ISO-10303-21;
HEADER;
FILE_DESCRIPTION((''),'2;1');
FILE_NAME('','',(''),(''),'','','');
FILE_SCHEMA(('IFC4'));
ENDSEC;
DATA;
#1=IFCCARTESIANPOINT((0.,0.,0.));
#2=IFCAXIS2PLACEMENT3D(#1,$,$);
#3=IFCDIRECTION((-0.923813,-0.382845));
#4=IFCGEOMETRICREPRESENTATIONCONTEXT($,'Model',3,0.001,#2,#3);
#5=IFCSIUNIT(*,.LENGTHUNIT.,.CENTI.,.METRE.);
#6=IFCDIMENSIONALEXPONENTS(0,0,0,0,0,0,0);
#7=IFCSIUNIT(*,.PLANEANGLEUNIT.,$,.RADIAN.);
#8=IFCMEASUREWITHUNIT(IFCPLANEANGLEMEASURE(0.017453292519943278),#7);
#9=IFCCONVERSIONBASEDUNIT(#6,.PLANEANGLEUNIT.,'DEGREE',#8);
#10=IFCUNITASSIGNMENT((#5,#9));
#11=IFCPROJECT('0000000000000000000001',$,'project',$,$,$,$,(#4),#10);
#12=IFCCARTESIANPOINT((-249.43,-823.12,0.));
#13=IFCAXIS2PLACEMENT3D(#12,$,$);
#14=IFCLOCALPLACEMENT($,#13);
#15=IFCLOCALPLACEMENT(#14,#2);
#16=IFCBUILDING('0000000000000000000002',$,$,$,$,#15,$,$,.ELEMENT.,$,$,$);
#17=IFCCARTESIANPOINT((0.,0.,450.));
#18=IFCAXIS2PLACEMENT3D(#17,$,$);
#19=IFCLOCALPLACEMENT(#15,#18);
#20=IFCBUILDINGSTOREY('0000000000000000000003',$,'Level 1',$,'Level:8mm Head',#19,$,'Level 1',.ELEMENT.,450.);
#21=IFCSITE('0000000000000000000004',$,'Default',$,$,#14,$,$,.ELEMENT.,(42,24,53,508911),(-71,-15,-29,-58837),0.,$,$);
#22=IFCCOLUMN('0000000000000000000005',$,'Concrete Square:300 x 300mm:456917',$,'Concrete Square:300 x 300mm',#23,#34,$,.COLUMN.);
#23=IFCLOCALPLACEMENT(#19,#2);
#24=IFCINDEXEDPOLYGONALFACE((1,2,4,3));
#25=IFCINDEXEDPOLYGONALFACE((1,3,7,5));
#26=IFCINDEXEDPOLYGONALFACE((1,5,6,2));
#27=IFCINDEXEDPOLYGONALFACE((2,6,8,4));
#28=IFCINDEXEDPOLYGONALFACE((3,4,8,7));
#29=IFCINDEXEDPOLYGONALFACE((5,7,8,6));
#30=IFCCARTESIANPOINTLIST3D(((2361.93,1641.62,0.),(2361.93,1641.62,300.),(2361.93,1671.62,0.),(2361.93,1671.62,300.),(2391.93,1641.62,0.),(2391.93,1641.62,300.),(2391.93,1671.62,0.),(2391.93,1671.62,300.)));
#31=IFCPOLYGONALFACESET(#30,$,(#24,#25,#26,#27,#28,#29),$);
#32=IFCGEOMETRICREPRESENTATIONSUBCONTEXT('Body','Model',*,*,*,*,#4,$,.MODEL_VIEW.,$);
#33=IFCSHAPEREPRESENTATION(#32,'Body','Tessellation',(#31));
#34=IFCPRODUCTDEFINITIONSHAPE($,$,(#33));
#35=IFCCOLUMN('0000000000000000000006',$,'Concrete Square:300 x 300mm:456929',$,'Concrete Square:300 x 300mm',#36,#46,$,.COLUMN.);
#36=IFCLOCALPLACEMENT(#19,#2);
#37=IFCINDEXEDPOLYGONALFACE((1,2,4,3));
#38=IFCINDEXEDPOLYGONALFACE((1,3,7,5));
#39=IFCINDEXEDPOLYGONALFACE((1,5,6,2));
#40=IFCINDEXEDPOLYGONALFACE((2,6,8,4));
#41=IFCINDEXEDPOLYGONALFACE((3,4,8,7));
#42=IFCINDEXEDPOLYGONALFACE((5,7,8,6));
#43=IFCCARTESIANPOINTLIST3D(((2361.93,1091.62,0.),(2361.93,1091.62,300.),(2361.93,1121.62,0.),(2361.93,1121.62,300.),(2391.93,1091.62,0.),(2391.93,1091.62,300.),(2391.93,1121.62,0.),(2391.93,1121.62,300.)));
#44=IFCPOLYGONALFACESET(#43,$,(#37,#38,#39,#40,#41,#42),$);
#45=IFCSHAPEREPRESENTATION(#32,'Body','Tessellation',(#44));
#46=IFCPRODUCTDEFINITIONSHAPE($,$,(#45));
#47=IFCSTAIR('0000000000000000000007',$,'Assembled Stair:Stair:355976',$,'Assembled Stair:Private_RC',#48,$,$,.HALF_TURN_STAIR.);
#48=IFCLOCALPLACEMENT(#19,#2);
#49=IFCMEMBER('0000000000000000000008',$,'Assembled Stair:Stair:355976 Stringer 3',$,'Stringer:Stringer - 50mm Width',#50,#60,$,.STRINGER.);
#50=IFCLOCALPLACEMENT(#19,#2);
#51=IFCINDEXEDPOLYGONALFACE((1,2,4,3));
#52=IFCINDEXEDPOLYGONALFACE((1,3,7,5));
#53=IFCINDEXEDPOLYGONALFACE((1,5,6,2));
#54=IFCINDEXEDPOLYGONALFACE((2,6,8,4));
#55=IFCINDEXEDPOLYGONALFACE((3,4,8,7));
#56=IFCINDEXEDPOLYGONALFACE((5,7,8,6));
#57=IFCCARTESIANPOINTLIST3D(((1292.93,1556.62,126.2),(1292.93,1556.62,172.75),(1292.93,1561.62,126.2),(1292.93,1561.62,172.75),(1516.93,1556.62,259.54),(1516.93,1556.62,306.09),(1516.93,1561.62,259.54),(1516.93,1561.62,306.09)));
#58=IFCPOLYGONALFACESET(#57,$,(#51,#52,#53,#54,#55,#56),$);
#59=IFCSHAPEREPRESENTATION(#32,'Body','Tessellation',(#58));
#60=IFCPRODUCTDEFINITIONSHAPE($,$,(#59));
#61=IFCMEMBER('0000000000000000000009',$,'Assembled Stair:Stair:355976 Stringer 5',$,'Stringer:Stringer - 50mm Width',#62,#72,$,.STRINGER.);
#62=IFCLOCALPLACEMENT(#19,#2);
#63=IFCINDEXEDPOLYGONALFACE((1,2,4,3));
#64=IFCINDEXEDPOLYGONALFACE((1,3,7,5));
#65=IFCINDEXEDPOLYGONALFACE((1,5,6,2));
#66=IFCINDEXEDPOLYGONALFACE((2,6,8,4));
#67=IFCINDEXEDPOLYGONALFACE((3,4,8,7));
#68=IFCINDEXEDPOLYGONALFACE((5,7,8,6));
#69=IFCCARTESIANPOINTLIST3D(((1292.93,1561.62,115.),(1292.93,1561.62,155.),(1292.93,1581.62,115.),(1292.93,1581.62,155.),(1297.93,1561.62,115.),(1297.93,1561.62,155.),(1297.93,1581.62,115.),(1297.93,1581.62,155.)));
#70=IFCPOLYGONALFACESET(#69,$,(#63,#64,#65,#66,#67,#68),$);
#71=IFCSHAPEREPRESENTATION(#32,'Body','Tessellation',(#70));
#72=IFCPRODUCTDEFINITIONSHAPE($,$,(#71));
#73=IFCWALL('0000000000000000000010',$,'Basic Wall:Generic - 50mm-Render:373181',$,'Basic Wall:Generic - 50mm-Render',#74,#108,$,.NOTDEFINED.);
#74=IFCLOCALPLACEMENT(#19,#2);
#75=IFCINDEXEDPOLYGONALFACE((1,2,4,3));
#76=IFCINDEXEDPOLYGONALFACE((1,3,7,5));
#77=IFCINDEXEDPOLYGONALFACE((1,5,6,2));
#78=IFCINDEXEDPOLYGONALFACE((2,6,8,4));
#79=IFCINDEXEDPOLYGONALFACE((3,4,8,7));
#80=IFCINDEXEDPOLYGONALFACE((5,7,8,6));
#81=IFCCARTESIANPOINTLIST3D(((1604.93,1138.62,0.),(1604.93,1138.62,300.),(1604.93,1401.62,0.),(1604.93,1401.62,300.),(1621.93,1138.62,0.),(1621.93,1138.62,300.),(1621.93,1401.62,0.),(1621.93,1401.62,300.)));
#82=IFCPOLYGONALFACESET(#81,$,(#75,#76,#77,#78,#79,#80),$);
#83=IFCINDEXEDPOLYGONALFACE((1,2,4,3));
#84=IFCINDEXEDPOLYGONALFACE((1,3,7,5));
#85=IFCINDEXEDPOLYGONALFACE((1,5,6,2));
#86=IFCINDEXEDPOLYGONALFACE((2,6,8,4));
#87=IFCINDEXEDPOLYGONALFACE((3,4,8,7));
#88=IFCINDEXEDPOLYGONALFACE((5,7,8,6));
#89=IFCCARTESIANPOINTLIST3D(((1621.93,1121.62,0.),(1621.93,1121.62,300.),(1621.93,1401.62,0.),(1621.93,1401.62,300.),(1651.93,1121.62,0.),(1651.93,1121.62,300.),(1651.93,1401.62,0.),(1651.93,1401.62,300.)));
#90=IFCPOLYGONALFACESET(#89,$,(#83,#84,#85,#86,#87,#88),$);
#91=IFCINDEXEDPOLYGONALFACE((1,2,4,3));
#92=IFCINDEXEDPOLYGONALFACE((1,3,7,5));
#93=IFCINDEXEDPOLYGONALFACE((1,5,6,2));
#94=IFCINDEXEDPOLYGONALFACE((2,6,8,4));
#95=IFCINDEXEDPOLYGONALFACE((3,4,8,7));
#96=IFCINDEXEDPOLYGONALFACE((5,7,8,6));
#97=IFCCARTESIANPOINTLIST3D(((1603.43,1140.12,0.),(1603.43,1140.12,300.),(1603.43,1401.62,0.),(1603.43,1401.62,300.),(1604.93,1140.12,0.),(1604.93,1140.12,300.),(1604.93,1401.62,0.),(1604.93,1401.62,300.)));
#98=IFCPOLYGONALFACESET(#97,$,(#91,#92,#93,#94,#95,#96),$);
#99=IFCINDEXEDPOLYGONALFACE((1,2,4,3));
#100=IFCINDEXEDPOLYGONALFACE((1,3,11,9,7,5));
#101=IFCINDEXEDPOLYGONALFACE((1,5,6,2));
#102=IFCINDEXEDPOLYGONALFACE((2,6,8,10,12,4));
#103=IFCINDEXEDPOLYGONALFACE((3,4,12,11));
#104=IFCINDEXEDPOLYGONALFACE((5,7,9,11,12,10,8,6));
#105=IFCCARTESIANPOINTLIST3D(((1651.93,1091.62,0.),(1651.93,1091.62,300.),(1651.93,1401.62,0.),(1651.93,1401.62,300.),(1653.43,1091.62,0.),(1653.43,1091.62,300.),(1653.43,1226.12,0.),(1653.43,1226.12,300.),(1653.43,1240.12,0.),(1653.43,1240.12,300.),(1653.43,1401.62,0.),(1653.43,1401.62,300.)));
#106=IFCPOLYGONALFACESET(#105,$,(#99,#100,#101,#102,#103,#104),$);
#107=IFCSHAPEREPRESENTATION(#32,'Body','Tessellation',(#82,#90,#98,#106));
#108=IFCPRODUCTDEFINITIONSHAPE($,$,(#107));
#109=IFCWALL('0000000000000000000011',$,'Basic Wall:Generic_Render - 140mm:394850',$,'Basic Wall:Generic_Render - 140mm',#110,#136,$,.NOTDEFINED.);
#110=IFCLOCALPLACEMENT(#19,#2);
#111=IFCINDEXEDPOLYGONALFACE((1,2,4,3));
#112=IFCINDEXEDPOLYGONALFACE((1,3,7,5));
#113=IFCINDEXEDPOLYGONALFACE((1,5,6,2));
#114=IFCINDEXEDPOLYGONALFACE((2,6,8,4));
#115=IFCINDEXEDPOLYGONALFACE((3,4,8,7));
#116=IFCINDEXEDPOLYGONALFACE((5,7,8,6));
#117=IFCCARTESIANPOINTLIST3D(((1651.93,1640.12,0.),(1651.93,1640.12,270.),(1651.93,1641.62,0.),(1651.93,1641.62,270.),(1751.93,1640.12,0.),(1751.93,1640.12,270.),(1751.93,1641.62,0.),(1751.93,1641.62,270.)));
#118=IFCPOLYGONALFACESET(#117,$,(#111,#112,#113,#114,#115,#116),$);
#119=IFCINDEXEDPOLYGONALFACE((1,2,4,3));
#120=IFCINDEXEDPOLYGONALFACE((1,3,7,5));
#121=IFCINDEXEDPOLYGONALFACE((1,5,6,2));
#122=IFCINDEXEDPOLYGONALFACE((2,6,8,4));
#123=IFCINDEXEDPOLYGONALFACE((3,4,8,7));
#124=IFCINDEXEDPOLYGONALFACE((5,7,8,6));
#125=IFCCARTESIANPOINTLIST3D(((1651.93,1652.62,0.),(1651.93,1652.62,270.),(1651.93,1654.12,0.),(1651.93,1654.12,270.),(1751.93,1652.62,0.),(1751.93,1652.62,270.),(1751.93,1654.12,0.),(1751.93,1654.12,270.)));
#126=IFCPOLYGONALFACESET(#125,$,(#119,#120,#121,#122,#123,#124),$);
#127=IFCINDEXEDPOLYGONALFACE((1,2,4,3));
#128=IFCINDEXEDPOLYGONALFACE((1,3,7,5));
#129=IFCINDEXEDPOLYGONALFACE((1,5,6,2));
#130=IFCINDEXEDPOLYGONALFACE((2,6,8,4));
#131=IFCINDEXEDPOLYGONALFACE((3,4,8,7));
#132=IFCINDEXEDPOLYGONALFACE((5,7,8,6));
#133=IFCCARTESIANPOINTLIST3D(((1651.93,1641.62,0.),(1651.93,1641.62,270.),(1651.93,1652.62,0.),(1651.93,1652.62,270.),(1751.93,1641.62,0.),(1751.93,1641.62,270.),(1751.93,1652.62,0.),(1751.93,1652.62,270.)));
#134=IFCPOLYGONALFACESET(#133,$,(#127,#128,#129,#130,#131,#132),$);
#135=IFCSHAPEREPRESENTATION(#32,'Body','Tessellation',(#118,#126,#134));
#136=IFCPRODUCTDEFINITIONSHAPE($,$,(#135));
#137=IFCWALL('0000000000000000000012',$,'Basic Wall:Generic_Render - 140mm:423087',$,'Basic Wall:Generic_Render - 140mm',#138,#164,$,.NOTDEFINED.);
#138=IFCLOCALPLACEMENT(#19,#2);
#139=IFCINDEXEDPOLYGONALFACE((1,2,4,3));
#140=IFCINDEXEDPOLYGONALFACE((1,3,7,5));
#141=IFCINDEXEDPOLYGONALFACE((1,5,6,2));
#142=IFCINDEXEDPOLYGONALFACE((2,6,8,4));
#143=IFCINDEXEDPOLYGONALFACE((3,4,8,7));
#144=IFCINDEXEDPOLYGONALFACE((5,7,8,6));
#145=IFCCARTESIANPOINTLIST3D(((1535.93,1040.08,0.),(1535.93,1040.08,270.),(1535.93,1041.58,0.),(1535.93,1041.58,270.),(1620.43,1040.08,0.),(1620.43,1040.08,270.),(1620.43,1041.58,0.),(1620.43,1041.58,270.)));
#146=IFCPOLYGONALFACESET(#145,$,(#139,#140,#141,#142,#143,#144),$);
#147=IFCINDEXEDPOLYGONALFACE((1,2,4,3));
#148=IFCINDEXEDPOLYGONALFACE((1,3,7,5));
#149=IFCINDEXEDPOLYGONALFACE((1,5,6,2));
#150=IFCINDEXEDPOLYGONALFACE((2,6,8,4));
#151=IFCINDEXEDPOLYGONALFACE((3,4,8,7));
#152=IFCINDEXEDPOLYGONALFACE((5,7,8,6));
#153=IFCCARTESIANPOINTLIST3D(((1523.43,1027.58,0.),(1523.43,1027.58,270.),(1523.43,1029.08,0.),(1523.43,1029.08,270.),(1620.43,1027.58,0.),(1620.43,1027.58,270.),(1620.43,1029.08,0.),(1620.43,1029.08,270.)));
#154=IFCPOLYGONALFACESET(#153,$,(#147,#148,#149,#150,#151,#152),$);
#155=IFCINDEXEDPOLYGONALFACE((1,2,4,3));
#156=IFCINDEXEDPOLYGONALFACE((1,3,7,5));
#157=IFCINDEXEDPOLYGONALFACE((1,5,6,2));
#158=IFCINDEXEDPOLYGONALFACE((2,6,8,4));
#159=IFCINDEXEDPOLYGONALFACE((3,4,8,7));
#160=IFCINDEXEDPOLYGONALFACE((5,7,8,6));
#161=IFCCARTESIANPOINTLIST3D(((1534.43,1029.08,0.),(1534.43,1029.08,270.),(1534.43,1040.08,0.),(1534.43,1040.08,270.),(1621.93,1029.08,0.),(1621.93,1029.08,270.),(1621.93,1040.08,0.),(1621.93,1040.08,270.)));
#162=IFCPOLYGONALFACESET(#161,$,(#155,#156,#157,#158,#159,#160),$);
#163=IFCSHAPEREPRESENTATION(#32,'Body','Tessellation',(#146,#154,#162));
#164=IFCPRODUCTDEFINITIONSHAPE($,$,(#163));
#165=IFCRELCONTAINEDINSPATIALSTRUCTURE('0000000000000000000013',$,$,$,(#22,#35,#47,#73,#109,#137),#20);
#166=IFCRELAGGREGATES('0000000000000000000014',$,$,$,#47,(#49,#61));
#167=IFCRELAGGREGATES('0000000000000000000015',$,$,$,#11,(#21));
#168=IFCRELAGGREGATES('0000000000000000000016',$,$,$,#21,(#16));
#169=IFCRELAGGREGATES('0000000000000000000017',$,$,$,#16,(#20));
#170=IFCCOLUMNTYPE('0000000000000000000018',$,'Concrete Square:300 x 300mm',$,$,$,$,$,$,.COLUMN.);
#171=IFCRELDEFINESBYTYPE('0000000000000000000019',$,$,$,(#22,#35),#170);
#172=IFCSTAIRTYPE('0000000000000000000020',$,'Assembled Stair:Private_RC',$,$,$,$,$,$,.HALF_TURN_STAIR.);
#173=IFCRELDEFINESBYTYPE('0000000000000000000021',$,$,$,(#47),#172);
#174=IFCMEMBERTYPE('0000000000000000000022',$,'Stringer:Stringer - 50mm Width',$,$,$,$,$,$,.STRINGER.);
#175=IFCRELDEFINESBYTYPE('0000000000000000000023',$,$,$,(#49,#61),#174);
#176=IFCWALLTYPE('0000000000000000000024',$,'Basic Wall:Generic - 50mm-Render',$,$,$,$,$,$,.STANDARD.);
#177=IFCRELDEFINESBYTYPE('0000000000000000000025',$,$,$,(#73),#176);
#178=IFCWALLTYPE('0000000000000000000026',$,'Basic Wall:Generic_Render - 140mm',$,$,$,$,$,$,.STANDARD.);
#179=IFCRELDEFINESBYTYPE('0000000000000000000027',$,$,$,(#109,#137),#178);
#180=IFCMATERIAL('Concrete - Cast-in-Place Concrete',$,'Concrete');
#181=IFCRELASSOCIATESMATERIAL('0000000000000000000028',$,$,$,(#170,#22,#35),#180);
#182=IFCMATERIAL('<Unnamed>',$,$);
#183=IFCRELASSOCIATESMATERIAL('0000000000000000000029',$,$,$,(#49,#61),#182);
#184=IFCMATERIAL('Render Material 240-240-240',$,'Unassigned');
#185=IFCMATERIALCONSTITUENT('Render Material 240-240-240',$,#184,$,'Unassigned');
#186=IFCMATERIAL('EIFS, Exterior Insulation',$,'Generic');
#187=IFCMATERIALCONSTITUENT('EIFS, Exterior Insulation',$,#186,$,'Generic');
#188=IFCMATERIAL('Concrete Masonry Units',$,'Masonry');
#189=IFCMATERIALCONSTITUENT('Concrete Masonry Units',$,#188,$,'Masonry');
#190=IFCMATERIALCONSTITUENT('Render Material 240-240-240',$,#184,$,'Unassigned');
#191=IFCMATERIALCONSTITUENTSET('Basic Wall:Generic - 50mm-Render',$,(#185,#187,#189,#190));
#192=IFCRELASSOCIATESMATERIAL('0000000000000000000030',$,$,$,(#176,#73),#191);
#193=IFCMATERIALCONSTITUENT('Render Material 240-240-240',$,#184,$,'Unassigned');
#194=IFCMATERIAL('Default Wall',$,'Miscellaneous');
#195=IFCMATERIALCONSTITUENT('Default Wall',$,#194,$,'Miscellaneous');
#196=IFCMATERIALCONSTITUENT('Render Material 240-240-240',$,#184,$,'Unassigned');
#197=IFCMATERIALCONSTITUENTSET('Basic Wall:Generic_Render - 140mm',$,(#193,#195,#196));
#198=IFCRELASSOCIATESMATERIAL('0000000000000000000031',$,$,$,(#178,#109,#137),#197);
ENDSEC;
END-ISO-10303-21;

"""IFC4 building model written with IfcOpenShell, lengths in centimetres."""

from ifc_helpers import new_model, entity, si_unit, converted_unit, direction, frame, origin, place, context, subcontext, project, spatial, indexed_curve, outline, extrude, source, transform, mapped, material, constituent, constituent_set, type_object, type_shapes, element, aggregate, save


model = new_model("IFC4")

# Units and contexts
model_context = context("Model", 3, precision=0.001, world=origin(), true_north=direction((-0.923813, -0.382845)))
body_context = subcontext(model_context, "Body", "Model", "MODEL_VIEW")
ifc_project = project(units=[si_unit("LENGTHUNIT", "METRE", prefix="CENTI"), converted_unit("PLANEANGLEUNIT", "DEGREE", entity("IfcPlaneAngleMeasure", 0.017453292519943278), si_unit("PLANEANGLEUNIT", "RADIAN"), dimensions=[0, 0, 0, 0, 0, 0, 0])], contexts=[model_context])

# Site, building, storey
site_placement = place(None, frame((-249.43, -823.12, 0.0)))
site = spatial("IfcSite", under=ifc_project, at=site_placement, Name="Default", CompositionType="ELEMENT", RefLatitude=(42, 24, 53, 508911), RefLongitude=(-71, -15, -29, -58837), RefElevation=0.0)
building_placement = place(site_placement, origin())
building = spatial("IfcBuilding", under=site, at=building_placement, CompositionType="ELEMENT")
storey_placement = place(building_placement, frame((0.0, 0.0, 450.0)))
storey = spatial("IfcBuildingStorey", under=building, at=storey_placement, Name="Level 1", ObjectType="Level:8mm Head", LongName="Level 1", CompositionType="ELEMENT", Elevation=450.0)

# Columns
ifc_material_1 = material(Name="Concrete - Cast-in-Place Concrete", Category="Concrete")
column_type = type_object("IfcColumnType", Name="Concrete Square:300 x 300mm", PredefinedType="COLUMN", material=ifc_material_1)
shared_shape_1 = source(origin(), body_context, "Body", "SweptSolid", [
    extrude(outline(indexed_curve([(-15.0, -15.0), (15.0, -15.0), (15.0, 15.0), (-15.0, 15.0), (-15.0, -15.0)], self_intersect=False)), frame((0.0, 0.0, 450.0), z_axis=(0.0, 0.0, 1.0), x_axis=(-1.0, 0.0, 0.0)), (0.0, 0.0, 1.0), 300.0),
])
type_shapes(column_type, [shared_shape_1])
for number, where, name in (
    (1, (2376.93, 1656.62, -450.0), "Concrete Square:300 x 300mm:456917"),
    (2, (2376.93, 1106.62, -450.0), "Concrete Square:300 x 300mm:456929"),
):
    element("IfcColumn", number, at=place(storey_placement, frame(where)), inside=storey, type_object=column_type, material=ifc_material_1, Name=name, ObjectType="Concrete Square:300 x 300mm", PredefinedType="COLUMN", context=body_context, shape_type="MappedRepresentation", body=[
        mapped(shared_shape_1, transform((0.0, 0.0, 0.0), scale=1.0)),
    ])

# Stair, members
stair_type = type_object("IfcStairType", Name="Assembled Stair:Private_RC", PredefinedType="HALF_TURN_STAIR")
stair_placement = place(storey_placement, origin())
stair = element("IfcStair", 3, at=stair_placement, inside=storey, type_object=stair_type, Name="Assembled Stair:Stair:355976", ObjectType="Assembled Stair:Private_RC", PredefinedType="HALF_TURN_STAIR")
ifc_material_2 = material(Name="<Unnamed>")
member_type = type_object("IfcMemberType", Name="Stringer:Stringer - 50mm Width", PredefinedType="STRINGER")
member_1_placement = place(stair_placement, frame((1292.93, 1556.62, 126.2)))
member_1 = element("IfcMember", 4, at=member_1_placement, type_object=member_type, material=ifc_material_2, Name="Assembled Stair:Stair:355976 Stringer 3", ObjectType="Stringer:Stringer - 50mm Width", PredefinedType="STRINGER", context=body_context, shape_type="SweptSolid", body=[
    extrude(outline(indexed_curve([(-118.43, -20.0), (142.24, -20.0), (118.43, 20.0), (-142.24, 20.0), (-118.43, -20.0)], self_intersect=False)), frame((112.0, 0.0, 89.94), z_axis=(0.0, 1.0, 0.0), x_axis=(0.859293, 0.0, 0.511484)), (0.0, 0.0, 1.0), 5.0),
])
member_2_placement = place(stair_placement, frame((1292.93, 1561.62, 115.0)))
member_2 = element("IfcMember", 5, at=member_2_placement, type_object=member_type, material=ifc_material_2, Name="Assembled Stair:Stair:355976 Stringer 5", ObjectType="Stringer:Stringer - 50mm Width", PredefinedType="STRINGER", context=body_context, shape_type="SweptSolid", body=[
    extrude(outline(indexed_curve([(-10.0, -2.5), (10.0, -2.5), (10.0, 2.5), (-10.0, 2.5), (-10.0, -2.5)], self_intersect=False)), frame((2.5, 10.0, 0.0), z_axis=(0.0, 0.0, 1.0), x_axis=(0.0, 1.0, 0.0)), (0.0, 0.0, 1.0), 40.0),
])
aggregate(stair, [member_1, member_2])

# Walls
ifc_material_3 = material(Name="Render Material 240-240-240", Category="Unassigned")
ifc_material_4 = material(Name="Default Wall", Category="Miscellaneous")
ifc_constituent_1 = constituent(ifc_material_3, Name="Render Material 240-240-240", Category="Unassigned")
ifc_material_5 = material(Name="EIFS, Exterior Insulation", Category="Generic")
ifc_constituent_2 = constituent(ifc_material_5, Name="EIFS, Exterior Insulation", Category="Generic")
ifc_material_6 = material(Name="Concrete Masonry Units", Category="Masonry")
ifc_constituent_3 = constituent(ifc_material_6, Name="Concrete Masonry Units", Category="Masonry")
ifc_constituent_4 = constituent(ifc_material_3, Name="Render Material 240-240-240", Category="Unassigned")
ifc_constituent_set_1 = constituent_set(constituents=[ifc_constituent_1, ifc_constituent_2, ifc_constituent_3, ifc_constituent_4], Name="Basic Wall:Generic - 50mm-Render")
wall_type_1 = type_object("IfcWallType", Name="Basic Wall:Generic - 50mm-Render", PredefinedType="STANDARD", material=ifc_constituent_set_1)
wall_1_placement = place(storey_placement, frame((1628.43, 1401.62, 0.0), z_axis=(0.0, 0.0, 1.0), x_axis=(0.0, -1.0, 0.0)))
element("IfcWall", 6, at=wall_1_placement, inside=storey, type_object=wall_type_1, material=ifc_constituent_set_1, Name="Basic Wall:Generic - 50mm-Render:373181", ObjectType="Basic Wall:Generic - 50mm-Render", PredefinedType="NOTDEFINED", context=body_context, shape_type="SweptSolid", body=[
    extrude(outline(indexed_curve([(-8.5, -131.5), (8.5, -131.5), (8.5, 131.5), (-8.5, 131.5), (-8.5, -131.5)], self_intersect=False)), frame((131.5, -15.0, 0.0), z_axis=(0.0, 0.0, 1.0), x_axis=(0.0, 1.0, 0.0)), (0.0, 0.0, 1.0), 300.0),
    extrude(outline(indexed_curve([(-15.0, -140.0), (15.0, -140.0), (15.0, 140.0), (-15.0, 140.0), (-15.0, -140.0)], self_intersect=False)), frame((140.0, 8.5, 0.0), z_axis=(0.0, 0.0, 1.0), x_axis=(0.0, -1.0, 0.0)), (0.0, 0.0, 1.0), 300.0),
    extrude(outline(indexed_curve([(-0.75, -130.75), (0.75, -130.75), (0.75, 130.75), (-0.75, 130.75), (-0.75, -130.75)], self_intersect=False)), frame((130.75, -24.25, 0.0), z_axis=(0.0, 0.0, 1.0), x_axis=(0.0, 1.0, 0.0)), (0.0, 0.0, 1.0), 300.0),
    extrude(outline(indexed_curve([(-1.0, -150.5), (0.5, -150.5), (0.5, -16.0), (0.5, -2.0), (0.5, 159.5), (-1.0, 159.5), (-1.0, -150.5)], self_intersect=False)), frame((159.5, 24.5, 0.0), z_axis=(0.0, 0.0, 1.0), x_axis=(0.0, 1.0, 0.0)), (0.0, 0.0, 1.0), 300.0),
])
ifc_constituent_5 = constituent(ifc_material_3, Name="Render Material 240-240-240", Category="Unassigned")
ifc_constituent_6 = constituent(ifc_material_4, Name="Default Wall", Category="Miscellaneous")
ifc_constituent_7 = constituent(ifc_material_3, Name="Render Material 240-240-240", Category="Unassigned")
ifc_constituent_set_2 = constituent_set(constituents=[ifc_constituent_5, ifc_constituent_6, ifc_constituent_7], Name="Basic Wall:Generic_Render - 140mm")
wall_type_2 = type_object("IfcWallType", Name="Basic Wall:Generic_Render - 140mm", PredefinedType="STANDARD", material=ifc_constituent_set_2)
wall_2_placement = place(storey_placement, frame((1651.93, 1647.12, 0.0)))
element("IfcWall", 7, at=wall_2_placement, inside=storey, type_object=wall_type_2, material=ifc_constituent_set_2, Name="Basic Wall:Generic_Render - 140mm:394850", ObjectType="Basic Wall:Generic_Render - 140mm", PredefinedType="NOTDEFINED", context=body_context, shape_type="SweptSolid", body=[
    extrude(outline(indexed_curve([(-0.75, -50.0), (0.75, -50.0), (0.75, 50.0), (-0.75, 50.0), (-0.75, -50.0)], self_intersect=False)), frame((50.0, -6.25, 0.0), z_axis=(0.0, 0.0, 1.0), x_axis=(0.0, 1.0, 0.0)), (0.0, 0.0, 1.0), 270.0),
    extrude(outline(indexed_curve([(-0.75, -50.0), (0.75, -50.0), (0.75, 50.0), (-0.75, 50.0), (-0.75, -50.0)], self_intersect=False)), frame((50.0, 6.25, 0.0), z_axis=(0.0, 0.0, 1.0), x_axis=(0.0, -1.0, 0.0)), (0.0, 0.0, 1.0), 270.0),
    extrude(outline(indexed_curve([(-50.0, -5.5), (50.0, -5.5), (50.0, 5.5), (-50.0, 5.5), (-50.0, -5.5)], self_intersect=False)), frame((50.0, 0.0, 0.0)), (0.0, 0.0, 1.0), 270.0),
])
wall_3_placement = place(storey_placement, frame((1535.93, 1034.58, 0.0)))
element("IfcWall", 8, at=wall_3_placement, inside=storey, type_object=wall_type_2, material=ifc_constituent_set_2, Name="Basic Wall:Generic_Render - 140mm:423087", ObjectType="Basic Wall:Generic_Render - 140mm", PredefinedType="NOTDEFINED", context=body_context, shape_type="SweptSolid", body=[
    extrude(outline(indexed_curve([(-0.75, -42.25), (0.75, -42.25), (0.75, 42.25), (-0.75, 42.25), (-0.75, -42.25)], self_intersect=False)), frame((42.25, 6.25, 0.0), z_axis=(0.0, 0.0, 1.0), x_axis=(0.0, -1.0, 0.0)), (0.0, 0.0, 1.0), 270.0),
    extrude(outline(indexed_curve([(-0.75, -48.5), (0.75, -48.5), (0.75, 48.5), (-0.75, 48.5), (-0.75, -48.5)], self_intersect=False)), frame((36.0, -6.25, 0.0), z_axis=(0.0, 0.0, 1.0), x_axis=(0.0, 1.0, 0.0)), (0.0, 0.0, 1.0), 270.0),
    extrude(outline(indexed_curve([(-43.75, -5.5), (43.75, -5.5), (43.75, 5.5), (-43.75, 5.5), (-43.75, -5.5)], self_intersect=False)), frame((42.25, 0.0, 0.0)), (0.0, 0.0, 1.0), 270.0),
])

save(model, "model.ifc")
